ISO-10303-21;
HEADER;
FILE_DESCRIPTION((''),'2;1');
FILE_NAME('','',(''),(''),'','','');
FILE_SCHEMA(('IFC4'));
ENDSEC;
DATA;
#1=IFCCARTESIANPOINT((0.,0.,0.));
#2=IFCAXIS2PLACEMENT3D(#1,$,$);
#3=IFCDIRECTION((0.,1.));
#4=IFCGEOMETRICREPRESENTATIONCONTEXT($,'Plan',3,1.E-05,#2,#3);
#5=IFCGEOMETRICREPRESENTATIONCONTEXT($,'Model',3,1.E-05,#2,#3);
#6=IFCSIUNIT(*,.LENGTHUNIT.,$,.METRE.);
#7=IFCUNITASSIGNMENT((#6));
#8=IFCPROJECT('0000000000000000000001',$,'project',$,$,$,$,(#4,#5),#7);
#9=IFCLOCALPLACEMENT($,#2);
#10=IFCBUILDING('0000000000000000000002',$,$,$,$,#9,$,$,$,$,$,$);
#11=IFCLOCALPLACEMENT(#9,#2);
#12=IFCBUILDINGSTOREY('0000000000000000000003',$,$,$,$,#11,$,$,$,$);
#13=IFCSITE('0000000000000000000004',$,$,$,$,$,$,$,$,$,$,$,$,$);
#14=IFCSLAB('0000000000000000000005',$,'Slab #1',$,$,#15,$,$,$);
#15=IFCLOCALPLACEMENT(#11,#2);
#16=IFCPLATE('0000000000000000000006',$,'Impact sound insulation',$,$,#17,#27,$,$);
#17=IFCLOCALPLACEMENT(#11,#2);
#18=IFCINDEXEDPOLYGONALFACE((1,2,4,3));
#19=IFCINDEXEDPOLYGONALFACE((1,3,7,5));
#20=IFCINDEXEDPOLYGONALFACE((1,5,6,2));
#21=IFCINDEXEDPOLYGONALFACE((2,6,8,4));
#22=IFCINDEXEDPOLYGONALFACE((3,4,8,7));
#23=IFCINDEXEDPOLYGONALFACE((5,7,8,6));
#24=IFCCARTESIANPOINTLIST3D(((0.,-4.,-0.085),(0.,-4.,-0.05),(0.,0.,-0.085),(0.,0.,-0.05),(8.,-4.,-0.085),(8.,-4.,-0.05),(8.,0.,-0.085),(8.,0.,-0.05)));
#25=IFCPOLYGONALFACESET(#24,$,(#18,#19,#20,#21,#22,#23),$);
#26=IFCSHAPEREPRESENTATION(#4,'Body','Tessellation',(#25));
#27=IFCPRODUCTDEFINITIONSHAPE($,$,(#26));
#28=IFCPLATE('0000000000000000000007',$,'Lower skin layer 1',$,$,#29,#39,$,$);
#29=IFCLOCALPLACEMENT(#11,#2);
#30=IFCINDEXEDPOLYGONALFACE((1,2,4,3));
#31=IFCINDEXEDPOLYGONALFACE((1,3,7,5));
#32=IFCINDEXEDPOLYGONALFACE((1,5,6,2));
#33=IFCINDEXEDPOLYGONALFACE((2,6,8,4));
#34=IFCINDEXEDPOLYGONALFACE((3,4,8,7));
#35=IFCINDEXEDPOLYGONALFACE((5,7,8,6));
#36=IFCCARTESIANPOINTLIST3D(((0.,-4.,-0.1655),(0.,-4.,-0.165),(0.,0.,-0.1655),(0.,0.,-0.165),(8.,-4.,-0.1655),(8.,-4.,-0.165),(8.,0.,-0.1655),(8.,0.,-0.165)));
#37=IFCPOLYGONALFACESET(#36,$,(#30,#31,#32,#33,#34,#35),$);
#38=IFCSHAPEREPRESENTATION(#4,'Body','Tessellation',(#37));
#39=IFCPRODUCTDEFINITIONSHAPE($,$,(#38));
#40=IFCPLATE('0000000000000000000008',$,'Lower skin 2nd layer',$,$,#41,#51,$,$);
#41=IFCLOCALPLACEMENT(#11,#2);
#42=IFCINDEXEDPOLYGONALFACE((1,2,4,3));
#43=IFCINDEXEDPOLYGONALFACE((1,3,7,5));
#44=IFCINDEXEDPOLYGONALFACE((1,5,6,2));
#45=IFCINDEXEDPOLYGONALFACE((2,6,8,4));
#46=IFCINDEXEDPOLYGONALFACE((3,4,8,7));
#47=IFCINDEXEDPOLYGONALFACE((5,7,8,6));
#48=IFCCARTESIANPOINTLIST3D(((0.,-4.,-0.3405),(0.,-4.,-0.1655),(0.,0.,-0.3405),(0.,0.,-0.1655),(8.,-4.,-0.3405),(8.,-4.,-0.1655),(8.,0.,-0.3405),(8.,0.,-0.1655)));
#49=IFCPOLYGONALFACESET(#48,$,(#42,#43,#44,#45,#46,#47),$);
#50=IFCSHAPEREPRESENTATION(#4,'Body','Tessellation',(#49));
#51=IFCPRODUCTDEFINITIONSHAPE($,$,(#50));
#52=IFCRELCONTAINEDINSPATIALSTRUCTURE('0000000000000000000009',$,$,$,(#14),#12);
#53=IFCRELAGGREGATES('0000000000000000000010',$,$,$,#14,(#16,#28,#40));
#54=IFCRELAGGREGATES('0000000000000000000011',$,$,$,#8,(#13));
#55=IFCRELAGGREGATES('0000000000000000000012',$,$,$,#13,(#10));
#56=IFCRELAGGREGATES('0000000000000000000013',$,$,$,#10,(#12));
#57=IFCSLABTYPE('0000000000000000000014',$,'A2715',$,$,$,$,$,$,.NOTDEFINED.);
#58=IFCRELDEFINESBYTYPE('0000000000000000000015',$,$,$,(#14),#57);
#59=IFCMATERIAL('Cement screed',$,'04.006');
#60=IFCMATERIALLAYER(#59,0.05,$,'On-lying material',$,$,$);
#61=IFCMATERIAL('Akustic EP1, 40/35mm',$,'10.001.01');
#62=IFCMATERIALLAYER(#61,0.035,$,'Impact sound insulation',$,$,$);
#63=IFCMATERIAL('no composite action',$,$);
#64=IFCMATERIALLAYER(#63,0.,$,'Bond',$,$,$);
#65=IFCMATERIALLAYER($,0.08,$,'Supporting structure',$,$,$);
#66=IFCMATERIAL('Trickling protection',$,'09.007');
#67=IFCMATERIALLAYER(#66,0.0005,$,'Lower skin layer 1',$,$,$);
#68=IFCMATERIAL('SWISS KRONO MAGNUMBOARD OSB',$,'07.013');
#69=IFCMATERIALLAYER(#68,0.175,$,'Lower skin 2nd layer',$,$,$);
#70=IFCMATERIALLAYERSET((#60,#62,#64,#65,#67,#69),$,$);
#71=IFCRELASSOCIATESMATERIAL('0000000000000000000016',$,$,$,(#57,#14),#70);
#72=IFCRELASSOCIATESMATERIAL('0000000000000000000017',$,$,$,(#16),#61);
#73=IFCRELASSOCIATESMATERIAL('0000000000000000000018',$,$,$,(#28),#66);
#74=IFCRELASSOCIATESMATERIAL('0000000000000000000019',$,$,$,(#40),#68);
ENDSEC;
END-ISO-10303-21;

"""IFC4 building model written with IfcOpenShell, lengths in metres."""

from ifc_helpers import new_model, si_unit, direction, frame, frame_2d, origin, place, context, project, spatial, rectangle, extrude, material, layer, layer_set, type_object, element, aggregate, save


model = new_model("IFC4")

# Units and contexts
plan_context = context("Plan", 3, precision=1e-05, world=origin(), true_north=direction((0.0, 1.0)))
model_context = context("Model", 3, precision=1e-05, world=origin(), true_north=direction((0.0, 1.0)))
ifc_project = project(units=[si_unit("LENGTHUNIT", "METRE")], contexts=[plan_context, model_context])

# Site, building, storey
site = spatial("IfcSite", under=ifc_project)
building_placement = place(None, origin())
building = spatial("IfcBuilding", under=site, at=building_placement)
storey_placement = place(building_placement, origin())
storey = spatial("IfcBuildingStorey", under=building, at=storey_placement)

# Slab, plates
ifc_material_1 = material(Name="Cement screed", Category="04.006")
ifc_layer_1 = layer(ifc_material_1, 0.05, Name="On-lying material")
ifc_material_2 = material(Name="Akustic EP1, 40/35mm", Category="10.001.01")
ifc_layer_2 = layer(ifc_material_2, 0.035, Name="Impact sound insulation")
ifc_material_3 = material(Name="no composite action")
ifc_layer_3 = layer(ifc_material_3, 0.0, Name="Bond")
ifc_layer_4 = layer(None, 0.08, Name="Supporting structure")
ifc_material_4 = material(Name="Trickling protection", Category="09.007")
ifc_layer_5 = layer(ifc_material_4, 0.0005, Name="Lower skin layer 1")
ifc_material_5 = material(Name="SWISS KRONO MAGNUMBOARD OSB", Category="07.013")
ifc_layer_6 = layer(ifc_material_5, 0.175, Name="Lower skin 2nd layer")
ifc_layer_set = layer_set([ifc_layer_1, ifc_layer_2, ifc_layer_3, ifc_layer_4, ifc_layer_5, ifc_layer_6])
slab_type = type_object("IfcSlabType", Name="A2715", PredefinedType="NOTDEFINED", material=ifc_layer_set)
slab_placement = place(None, frame((0.0, 0.0, 0.0), z_axis=(0.0, 0.0, -1.0), x_axis=(1.0, 0.0, 0.0)))
slab = element("IfcSlab", 1, at=slab_placement, inside=storey, type_object=slab_type, material=ifc_layer_set, Name="Slab #1")
plate_1_placement = place(slab_placement, origin())
plate_1 = element("IfcPlate", 2, at=plate_1_placement, material=ifc_material_2, Name="Impact sound insulation", context=plan_context, shape_type="SweptSolid", body=[
    extrude(rectangle(XDim=8.0, YDim=4.0, at=frame_2d((4.0, 2.0), x_axis=(1.0, 0.0))), frame((0.0, 0.0, 0.05), z_axis=(0.0, 0.0, 1.0), x_axis=(1.0, 0.0, 0.0)), (0.0, 0.0, 1.0), 0.035),
])
plate_2_placement = place(slab_placement, origin())
plate_2 = element("IfcPlate", 3, at=plate_2_placement, material=ifc_material_4, Name="Lower skin layer 1", context=plan_context, shape_type="SweptSolid", body=[
    extrude(rectangle(XDim=8.0, YDim=4.0, at=frame_2d((4.0, 2.0), x_axis=(1.0, 0.0))), frame((0.0, 0.0, 0.165), z_axis=(0.0, 0.0, 1.0), x_axis=(1.0, 0.0, 0.0)), (0.0, 0.0, 1.0), 0.0005),
])
plate_3_placement = place(slab_placement, origin())
plate_3 = element("IfcPlate", 4, at=plate_3_placement, material=ifc_material_5, Name="Lower skin 2nd layer", context=plan_context, shape_type="SweptSolid", body=[
    extrude(rectangle(XDim=8.0, YDim=4.0, at=frame_2d((4.0, 2.0), x_axis=(1.0, 0.0))), frame((0.0, 0.0, 0.1655), z_axis=(0.0, 0.0, 1.0), x_axis=(1.0, 0.0, 0.0)), (0.0, 0.0, 1.0), 0.175),
])
aggregate(slab, [plate_1, plate_2, plate_3])

save(model, "model.ifc")
